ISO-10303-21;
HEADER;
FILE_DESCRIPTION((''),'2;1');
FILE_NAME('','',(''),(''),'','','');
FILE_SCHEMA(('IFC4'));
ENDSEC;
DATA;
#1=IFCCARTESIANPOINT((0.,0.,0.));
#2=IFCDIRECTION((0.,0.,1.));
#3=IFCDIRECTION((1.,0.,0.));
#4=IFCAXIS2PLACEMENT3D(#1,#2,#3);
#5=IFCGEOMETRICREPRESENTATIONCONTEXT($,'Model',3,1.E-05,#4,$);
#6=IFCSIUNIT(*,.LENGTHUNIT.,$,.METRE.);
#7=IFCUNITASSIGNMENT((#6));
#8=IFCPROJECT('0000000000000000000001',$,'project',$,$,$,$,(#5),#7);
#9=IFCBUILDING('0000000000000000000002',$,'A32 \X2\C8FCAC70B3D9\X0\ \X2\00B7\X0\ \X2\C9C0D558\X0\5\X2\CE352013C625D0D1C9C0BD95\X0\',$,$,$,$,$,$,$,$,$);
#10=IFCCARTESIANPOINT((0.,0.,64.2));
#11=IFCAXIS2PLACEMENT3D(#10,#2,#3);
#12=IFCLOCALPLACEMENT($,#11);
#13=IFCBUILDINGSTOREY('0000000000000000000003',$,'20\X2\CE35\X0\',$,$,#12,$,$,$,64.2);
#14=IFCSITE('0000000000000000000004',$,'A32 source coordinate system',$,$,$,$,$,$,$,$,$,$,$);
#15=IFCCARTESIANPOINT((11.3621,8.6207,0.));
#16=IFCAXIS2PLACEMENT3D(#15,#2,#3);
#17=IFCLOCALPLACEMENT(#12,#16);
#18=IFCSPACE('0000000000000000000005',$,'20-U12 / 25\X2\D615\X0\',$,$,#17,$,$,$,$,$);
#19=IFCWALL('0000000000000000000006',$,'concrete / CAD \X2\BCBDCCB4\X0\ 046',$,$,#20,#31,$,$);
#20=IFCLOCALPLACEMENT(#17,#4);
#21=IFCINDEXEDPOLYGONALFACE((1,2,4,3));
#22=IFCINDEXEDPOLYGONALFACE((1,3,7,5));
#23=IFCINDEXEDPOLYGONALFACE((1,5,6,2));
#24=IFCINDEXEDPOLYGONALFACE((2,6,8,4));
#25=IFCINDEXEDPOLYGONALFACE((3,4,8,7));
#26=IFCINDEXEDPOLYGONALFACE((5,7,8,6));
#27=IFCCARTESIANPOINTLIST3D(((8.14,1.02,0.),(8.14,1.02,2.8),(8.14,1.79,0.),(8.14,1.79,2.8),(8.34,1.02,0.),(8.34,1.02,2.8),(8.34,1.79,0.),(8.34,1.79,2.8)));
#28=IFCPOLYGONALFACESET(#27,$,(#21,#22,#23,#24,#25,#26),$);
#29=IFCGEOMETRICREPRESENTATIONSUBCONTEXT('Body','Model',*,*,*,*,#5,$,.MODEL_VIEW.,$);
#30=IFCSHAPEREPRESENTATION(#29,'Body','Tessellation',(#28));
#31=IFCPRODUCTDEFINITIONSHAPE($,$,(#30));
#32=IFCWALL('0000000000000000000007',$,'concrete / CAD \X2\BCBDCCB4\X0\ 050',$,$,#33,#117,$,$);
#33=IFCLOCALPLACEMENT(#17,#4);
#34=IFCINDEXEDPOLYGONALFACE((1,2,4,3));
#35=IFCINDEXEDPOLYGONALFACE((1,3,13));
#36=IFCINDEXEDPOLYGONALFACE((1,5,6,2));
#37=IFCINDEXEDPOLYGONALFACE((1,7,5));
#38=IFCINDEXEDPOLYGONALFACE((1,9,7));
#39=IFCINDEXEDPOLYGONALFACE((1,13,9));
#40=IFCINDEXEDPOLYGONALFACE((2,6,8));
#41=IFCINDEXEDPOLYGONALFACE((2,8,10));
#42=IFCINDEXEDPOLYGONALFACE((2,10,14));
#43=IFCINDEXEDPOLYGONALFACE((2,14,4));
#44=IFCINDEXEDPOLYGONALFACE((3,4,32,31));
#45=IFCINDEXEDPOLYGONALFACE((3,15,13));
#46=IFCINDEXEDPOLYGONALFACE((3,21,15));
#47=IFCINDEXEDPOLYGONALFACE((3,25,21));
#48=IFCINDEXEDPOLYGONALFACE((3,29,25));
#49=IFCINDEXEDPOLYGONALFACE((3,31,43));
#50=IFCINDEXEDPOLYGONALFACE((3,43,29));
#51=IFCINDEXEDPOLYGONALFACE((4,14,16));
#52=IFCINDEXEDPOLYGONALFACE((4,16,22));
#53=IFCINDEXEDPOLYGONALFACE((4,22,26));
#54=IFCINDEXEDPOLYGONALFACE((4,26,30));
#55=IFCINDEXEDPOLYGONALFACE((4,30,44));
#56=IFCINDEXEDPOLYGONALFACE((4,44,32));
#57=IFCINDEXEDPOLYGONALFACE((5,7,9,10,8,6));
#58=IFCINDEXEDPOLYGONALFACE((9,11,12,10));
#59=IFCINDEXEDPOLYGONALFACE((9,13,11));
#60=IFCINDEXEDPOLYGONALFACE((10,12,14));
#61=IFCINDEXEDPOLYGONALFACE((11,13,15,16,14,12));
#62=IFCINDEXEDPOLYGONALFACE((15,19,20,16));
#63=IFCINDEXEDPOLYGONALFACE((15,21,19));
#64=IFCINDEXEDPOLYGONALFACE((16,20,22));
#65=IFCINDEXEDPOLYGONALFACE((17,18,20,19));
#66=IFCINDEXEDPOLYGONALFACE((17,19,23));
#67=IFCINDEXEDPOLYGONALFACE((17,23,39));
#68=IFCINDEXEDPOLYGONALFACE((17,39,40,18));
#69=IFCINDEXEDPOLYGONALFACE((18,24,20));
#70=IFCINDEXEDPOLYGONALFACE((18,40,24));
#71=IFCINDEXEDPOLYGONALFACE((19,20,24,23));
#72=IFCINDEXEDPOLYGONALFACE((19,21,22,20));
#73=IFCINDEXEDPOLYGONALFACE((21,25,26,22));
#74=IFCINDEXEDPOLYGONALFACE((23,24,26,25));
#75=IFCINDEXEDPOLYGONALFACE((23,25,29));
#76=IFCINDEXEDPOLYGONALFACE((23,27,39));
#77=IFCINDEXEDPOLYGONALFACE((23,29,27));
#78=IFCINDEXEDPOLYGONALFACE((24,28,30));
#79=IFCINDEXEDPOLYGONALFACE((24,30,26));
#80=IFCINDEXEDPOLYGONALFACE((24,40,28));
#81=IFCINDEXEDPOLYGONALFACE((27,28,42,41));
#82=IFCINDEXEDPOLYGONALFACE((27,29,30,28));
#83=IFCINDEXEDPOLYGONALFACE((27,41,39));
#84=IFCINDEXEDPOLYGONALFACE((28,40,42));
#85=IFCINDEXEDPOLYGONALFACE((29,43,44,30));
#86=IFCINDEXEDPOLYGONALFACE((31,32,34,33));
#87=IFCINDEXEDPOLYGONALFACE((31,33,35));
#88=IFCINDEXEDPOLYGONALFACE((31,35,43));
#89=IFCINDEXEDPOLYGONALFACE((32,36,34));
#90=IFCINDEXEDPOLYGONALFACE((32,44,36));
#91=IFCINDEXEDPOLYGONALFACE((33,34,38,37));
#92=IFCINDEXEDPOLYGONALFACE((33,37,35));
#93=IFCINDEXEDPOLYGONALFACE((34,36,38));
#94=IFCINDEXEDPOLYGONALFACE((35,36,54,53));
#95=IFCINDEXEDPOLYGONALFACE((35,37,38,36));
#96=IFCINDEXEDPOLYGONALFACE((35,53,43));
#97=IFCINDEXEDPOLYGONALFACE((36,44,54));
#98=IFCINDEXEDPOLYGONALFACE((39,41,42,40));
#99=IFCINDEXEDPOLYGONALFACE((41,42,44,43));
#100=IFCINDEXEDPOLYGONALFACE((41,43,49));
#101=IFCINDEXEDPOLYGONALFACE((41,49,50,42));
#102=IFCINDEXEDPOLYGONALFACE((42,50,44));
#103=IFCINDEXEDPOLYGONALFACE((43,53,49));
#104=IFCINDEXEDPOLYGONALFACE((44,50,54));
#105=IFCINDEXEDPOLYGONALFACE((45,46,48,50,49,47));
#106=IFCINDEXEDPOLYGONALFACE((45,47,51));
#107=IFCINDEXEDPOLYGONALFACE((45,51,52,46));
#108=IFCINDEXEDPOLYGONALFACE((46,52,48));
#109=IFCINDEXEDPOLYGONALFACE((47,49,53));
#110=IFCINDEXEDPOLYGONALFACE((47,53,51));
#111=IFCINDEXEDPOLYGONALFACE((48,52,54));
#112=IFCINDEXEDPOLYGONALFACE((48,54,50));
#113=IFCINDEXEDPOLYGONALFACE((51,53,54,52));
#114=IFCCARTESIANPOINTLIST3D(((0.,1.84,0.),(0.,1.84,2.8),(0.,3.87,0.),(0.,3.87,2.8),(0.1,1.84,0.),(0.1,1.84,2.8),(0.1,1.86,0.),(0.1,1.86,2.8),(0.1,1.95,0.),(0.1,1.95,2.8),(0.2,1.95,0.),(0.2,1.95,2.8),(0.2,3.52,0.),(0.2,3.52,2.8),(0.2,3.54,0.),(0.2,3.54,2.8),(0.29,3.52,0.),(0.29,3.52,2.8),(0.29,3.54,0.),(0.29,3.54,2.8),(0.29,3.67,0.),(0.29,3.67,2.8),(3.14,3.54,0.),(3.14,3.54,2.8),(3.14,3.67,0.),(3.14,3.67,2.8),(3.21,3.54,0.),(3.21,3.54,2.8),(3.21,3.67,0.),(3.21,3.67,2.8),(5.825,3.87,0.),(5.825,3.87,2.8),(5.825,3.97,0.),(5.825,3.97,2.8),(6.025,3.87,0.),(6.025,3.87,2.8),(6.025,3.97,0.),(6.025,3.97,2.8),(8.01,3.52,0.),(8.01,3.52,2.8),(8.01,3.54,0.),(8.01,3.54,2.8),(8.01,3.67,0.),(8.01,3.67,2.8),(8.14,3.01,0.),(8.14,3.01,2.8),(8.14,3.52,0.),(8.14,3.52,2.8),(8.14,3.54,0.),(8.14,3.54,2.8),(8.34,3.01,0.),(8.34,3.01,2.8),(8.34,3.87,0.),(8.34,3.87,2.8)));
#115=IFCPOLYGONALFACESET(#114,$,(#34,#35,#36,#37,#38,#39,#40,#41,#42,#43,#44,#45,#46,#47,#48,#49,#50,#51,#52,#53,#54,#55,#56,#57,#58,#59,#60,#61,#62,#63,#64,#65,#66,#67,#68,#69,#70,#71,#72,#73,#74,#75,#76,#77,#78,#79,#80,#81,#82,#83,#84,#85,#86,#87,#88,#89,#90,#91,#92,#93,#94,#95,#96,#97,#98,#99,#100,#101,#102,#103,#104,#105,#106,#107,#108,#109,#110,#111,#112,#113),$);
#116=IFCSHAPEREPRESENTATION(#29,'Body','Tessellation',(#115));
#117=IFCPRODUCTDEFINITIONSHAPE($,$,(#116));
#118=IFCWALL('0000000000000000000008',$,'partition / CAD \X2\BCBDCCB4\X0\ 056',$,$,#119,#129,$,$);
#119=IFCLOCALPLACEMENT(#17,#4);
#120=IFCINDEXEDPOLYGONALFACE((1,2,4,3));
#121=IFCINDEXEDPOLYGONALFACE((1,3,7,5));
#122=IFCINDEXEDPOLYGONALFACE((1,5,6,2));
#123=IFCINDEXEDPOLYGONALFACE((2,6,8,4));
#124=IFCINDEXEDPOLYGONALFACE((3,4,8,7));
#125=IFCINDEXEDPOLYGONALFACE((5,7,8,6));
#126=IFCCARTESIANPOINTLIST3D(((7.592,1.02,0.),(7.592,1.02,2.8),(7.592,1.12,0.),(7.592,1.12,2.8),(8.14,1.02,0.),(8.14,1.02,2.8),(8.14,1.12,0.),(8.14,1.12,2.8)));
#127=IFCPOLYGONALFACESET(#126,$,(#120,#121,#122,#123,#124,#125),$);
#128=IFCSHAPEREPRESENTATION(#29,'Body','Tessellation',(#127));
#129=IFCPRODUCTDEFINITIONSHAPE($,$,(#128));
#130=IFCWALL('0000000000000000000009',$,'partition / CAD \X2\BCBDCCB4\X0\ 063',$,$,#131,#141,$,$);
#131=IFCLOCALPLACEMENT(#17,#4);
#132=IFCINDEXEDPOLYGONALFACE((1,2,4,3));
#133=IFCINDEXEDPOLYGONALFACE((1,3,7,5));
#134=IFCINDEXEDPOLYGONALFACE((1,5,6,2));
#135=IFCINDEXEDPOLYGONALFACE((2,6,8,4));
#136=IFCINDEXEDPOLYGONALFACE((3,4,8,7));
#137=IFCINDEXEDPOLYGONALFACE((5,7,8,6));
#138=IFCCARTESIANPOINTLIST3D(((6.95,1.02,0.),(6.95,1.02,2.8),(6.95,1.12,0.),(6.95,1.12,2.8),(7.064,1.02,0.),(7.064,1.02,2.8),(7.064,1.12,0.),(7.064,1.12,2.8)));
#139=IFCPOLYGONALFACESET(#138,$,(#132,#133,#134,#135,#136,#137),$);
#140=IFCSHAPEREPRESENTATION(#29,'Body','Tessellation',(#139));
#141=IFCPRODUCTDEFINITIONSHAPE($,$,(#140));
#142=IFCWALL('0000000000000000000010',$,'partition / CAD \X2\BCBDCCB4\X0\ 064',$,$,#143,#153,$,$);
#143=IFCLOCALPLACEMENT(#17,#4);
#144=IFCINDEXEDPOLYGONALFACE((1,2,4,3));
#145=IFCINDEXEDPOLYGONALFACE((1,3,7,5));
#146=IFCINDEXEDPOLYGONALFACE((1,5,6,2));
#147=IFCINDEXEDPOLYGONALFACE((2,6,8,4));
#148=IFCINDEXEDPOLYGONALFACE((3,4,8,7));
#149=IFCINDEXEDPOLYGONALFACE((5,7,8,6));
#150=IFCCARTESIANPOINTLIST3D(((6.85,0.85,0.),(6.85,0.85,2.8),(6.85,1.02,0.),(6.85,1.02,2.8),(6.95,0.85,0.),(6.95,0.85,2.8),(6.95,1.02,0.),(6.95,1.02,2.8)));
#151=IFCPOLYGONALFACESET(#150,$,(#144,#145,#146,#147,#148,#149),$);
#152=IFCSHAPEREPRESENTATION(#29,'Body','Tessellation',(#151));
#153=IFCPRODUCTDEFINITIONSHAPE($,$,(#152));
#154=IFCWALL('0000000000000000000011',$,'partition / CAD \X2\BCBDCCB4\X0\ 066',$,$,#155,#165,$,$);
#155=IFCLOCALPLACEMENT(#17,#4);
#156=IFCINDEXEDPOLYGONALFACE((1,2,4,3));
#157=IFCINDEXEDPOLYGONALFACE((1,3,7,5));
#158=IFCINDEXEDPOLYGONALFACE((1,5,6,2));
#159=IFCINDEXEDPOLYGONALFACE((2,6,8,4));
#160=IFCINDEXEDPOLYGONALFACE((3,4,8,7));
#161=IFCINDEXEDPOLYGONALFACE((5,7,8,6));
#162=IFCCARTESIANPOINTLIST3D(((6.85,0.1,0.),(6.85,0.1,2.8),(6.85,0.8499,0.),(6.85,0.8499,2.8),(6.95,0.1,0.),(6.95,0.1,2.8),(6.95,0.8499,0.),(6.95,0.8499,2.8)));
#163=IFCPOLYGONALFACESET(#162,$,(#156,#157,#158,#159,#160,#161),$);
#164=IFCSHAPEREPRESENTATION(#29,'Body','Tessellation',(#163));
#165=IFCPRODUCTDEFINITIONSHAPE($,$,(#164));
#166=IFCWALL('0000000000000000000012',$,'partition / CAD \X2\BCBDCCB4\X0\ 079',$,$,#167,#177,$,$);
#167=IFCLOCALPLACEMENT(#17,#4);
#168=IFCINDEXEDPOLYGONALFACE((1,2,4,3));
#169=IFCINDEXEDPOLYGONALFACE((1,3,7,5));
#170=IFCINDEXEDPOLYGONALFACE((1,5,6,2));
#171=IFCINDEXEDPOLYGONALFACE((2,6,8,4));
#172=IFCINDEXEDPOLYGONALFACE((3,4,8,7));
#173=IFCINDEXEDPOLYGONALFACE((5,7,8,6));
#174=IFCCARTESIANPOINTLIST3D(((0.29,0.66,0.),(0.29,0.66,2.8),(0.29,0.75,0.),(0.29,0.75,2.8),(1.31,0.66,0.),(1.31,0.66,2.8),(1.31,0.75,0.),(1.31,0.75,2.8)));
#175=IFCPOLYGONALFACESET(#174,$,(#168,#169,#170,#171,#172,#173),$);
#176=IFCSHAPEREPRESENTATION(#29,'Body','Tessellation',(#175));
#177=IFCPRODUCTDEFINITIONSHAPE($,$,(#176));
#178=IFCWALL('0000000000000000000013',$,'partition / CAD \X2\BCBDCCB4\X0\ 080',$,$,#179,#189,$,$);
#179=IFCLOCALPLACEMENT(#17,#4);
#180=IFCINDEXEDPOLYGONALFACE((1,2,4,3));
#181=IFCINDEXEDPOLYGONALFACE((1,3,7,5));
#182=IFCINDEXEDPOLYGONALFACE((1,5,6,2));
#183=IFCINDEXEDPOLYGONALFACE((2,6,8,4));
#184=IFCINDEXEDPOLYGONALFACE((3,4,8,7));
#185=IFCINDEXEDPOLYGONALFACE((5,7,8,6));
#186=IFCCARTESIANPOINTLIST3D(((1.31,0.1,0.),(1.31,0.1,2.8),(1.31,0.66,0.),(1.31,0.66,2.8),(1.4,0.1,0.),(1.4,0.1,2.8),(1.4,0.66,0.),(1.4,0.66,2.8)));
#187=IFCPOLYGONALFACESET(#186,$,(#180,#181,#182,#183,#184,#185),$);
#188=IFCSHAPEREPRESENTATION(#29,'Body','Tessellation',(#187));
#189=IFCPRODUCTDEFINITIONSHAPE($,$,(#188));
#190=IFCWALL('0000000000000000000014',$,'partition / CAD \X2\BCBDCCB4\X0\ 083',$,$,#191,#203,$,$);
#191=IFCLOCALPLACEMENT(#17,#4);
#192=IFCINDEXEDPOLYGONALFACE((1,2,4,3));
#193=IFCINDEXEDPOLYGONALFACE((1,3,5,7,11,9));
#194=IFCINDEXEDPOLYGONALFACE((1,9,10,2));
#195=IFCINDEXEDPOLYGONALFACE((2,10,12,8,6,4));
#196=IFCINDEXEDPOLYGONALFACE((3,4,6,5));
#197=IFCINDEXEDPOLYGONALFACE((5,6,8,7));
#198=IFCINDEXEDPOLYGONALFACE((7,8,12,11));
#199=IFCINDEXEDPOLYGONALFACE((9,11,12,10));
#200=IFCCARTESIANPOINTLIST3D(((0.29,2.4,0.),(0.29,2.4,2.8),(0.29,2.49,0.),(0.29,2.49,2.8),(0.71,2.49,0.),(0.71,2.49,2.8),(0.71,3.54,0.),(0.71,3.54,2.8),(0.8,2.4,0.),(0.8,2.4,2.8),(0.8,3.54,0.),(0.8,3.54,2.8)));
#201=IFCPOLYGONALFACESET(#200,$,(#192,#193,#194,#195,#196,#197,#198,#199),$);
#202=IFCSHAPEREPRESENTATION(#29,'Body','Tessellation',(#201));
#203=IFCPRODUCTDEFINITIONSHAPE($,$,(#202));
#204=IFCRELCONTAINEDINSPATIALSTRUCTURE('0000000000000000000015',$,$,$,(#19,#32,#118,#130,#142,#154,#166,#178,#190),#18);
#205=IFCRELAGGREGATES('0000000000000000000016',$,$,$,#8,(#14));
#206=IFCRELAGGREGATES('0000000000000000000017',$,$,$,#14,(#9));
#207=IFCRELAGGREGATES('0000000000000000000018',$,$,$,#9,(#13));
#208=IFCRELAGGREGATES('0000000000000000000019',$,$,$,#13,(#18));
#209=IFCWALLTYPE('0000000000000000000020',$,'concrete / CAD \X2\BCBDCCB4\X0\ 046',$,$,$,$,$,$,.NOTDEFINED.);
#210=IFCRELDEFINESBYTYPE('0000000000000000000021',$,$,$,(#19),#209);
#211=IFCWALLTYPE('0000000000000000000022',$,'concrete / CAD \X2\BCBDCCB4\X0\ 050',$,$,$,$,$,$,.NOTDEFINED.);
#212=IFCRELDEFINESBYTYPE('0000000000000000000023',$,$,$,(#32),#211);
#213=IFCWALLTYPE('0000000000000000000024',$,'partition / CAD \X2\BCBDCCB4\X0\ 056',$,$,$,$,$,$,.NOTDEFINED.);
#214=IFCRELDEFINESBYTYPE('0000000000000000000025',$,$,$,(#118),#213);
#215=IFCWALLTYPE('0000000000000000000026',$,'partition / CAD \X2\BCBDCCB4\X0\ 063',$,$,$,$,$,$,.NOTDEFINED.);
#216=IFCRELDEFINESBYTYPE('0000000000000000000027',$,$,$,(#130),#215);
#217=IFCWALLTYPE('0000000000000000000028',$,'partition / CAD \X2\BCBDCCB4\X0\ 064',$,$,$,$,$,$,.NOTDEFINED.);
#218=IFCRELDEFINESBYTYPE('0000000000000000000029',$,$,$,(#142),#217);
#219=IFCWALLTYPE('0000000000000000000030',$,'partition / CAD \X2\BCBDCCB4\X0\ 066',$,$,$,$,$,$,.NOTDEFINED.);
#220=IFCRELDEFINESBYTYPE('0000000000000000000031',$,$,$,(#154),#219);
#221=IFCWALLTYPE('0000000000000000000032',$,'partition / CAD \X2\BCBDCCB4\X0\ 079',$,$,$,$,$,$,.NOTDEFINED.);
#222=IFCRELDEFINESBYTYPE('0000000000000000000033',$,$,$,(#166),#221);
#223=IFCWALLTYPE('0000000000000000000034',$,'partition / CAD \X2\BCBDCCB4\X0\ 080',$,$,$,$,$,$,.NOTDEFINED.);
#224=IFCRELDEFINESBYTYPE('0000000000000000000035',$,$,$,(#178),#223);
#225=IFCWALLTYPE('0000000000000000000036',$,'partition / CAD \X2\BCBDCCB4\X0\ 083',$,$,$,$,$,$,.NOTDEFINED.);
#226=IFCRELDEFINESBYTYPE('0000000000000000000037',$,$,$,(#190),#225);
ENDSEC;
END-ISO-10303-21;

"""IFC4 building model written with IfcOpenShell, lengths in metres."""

from ifc_helpers import new_model, si_unit, frame, origin, origin_with_axes, place, context, subcontext, project, spatial, polyline, outline, extrude, source, transform, mapped, type_object, type_shapes, element, save


model = new_model("IFC4")

# Units and contexts
model_context = context("Model", 3, precision=1e-05, world=origin_with_axes())
body_context = subcontext(model_context, "Body", "Model", "MODEL_VIEW")
ifc_project = project(units=[si_unit("LENGTHUNIT", "METRE")], contexts=[model_context])

# Site, building, storey, space
site = spatial("IfcSite", under=ifc_project, Name="A32 source coordinate system")
building = spatial("IfcBuilding", under=site, Name="A32 주거동 · 지하5층–옥탑지붕")
storey_placement = place(None, frame((0.0, 0.0, 64.2), z_axis=(0.0, 0.0, 1.0), x_axis=(1.0, 0.0, 0.0)))
storey = spatial("IfcBuildingStorey", under=building, at=storey_placement, Name="20층", Elevation=64.2)
space_1_placement = place(storey_placement, frame((11.3621, 8.6207, 0.0), z_axis=(0.0, 0.0, 1.0), x_axis=(1.0, 0.0, 0.0)))
space_1 = spatial("IfcSpace", under=storey, at=space_1_placement, Name="20-U12 / 25형")

# Walls
wall_type_1 = type_object("IfcWallType", Name="concrete / CAD 벽체 046", PredefinedType="NOTDEFINED")
shared_shape_1 = source(origin(), body_context, "Body", "SweptSolid", [
    extrude(outline(polyline([(8.14, 1.02), (8.14, 1.79), (8.34, 1.79), (8.34, 1.02), (8.14, 1.02)])), origin(), (0.0, 0.0, 1.0), 2.8),
])
type_shapes(wall_type_1, [shared_shape_1])
wall_1_placement = place(space_1_placement, origin_with_axes())
element("IfcWall", 1, at=wall_1_placement, inside=space_1, type_object=wall_type_1, Name="concrete / CAD 벽체 046", context=body_context, shape_type="MappedRepresentation", body=[
    mapped(shared_shape_1, transform((0.0, 0.0, 0.0), scale=1.0)),
])
wall_type_2 = type_object("IfcWallType", Name="concrete / CAD 벽체 050", PredefinedType="NOTDEFINED")
shared_shape_2 = source(origin(), body_context, "Body", "SweptSolid", [
    extrude(outline(polyline([(8.01, 3.52), (0.29, 3.52), (0.29, 3.54), (0.2, 3.54), (0.2, 3.52), (0.2, 1.95), (0.1, 1.95), (0.1, 1.86), (0.1, 1.84), (0.0, 1.84), (0.0, 3.87), (5.825, 3.87), (5.825, 3.97), (6.025, 3.97), (6.025, 3.87), (8.34, 3.87), (8.34, 3.01), (8.14, 3.01), (8.14, 3.52), (8.14, 3.54), (8.01, 3.54), (8.01, 3.52)]), holes=[polyline([(3.14, 3.54), (3.14, 3.67), (0.29, 3.67), (0.29, 3.54), (3.14, 3.54)]), polyline([(8.01, 3.67), (3.21, 3.67), (3.21, 3.54), (8.01, 3.54), (8.01, 3.67)])]), origin(), (0.0, 0.0, 1.0), 2.8),
])
type_shapes(wall_type_2, [shared_shape_2])
wall_2_placement = place(space_1_placement, origin_with_axes())
element("IfcWall", 2, at=wall_2_placement, inside=space_1, type_object=wall_type_2, Name="concrete / CAD 벽체 050", context=body_context, shape_type="MappedRepresentation", body=[
    mapped(shared_shape_2, transform((0.0, 0.0, 0.0), scale=1.0)),
])
wall_type_3 = type_object("IfcWallType", Name="partition / CAD 벽체 056", PredefinedType="NOTDEFINED")
shared_shape_3 = source(origin(), body_context, "Body", "SweptSolid", [
    extrude(outline(polyline([(7.592, 1.12), (8.14, 1.12), (8.14, 1.02), (7.592, 1.02), (7.592, 1.12)])), origin(), (0.0, 0.0, 1.0), 2.8),
])
type_shapes(wall_type_3, [shared_shape_3])
wall_3_placement = place(space_1_placement, origin_with_axes())
element("IfcWall", 3, at=wall_3_placement, inside=space_1, type_object=wall_type_3, Name="partition / CAD 벽체 056", context=body_context, shape_type="MappedRepresentation", body=[
    mapped(shared_shape_3, transform((0.0, 0.0, 0.0), scale=1.0)),
])
wall_type_4 = type_object("IfcWallType", Name="partition / CAD 벽체 063", PredefinedType="NOTDEFINED")
shared_shape_4 = source(origin(), body_context, "Body", "SweptSolid", [
    extrude(outline(polyline([(6.95, 1.12), (7.064, 1.12), (7.064, 1.02), (6.95, 1.02), (6.95, 1.12)])), origin(), (0.0, 0.0, 1.0), 2.8),
])
type_shapes(wall_type_4, [shared_shape_4])
wall_4_placement = place(space_1_placement, origin_with_axes())
element("IfcWall", 4, at=wall_4_placement, inside=space_1, type_object=wall_type_4, Name="partition / CAD 벽체 063", context=body_context, shape_type="MappedRepresentation", body=[
    mapped(shared_shape_4, transform((0.0, 0.0, 0.0), scale=1.0)),
])
wall_type_5 = type_object("IfcWallType", Name="partition / CAD 벽체 064", PredefinedType="NOTDEFINED")
shared_shape_5 = source(origin(), body_context, "Body", "SweptSolid", [
    extrude(outline(polyline([(6.95, 0.85), (6.85, 0.85), (6.85, 1.02), (6.95, 1.02), (6.95, 0.85)])), origin(), (0.0, 0.0, 1.0), 2.8),
])
type_shapes(wall_type_5, [shared_shape_5])
wall_5_placement = place(space_1_placement, origin_with_axes())
element("IfcWall", 5, at=wall_5_placement, inside=space_1, type_object=wall_type_5, Name="partition / CAD 벽체 064", context=body_context, shape_type="MappedRepresentation", body=[
    mapped(shared_shape_5, transform((0.0, 0.0, 0.0), scale=1.0)),
])
wall_type_6 = type_object("IfcWallType", Name="partition / CAD 벽체 066", PredefinedType="NOTDEFINED")
shared_shape_6 = source(origin(), body_context, "Body", "SweptSolid", [
    extrude(outline(polyline([(6.85, 0.8499), (6.95, 0.8499), (6.95, 0.1), (6.85, 0.1), (6.85, 0.8499)])), origin(), (0.0, 0.0, 1.0), 2.8),
])
type_shapes(wall_type_6, [shared_shape_6])
wall_6_placement = place(space_1_placement, origin_with_axes())
element("IfcWall", 6, at=wall_6_placement, inside=space_1, type_object=wall_type_6, Name="partition / CAD 벽체 066", context=body_context, shape_type="MappedRepresentation", body=[
    mapped(shared_shape_6, transform((0.0, 0.0, 0.0), scale=1.0)),
])
wall_type_7 = type_object("IfcWallType", Name="partition / CAD 벽체 079", PredefinedType="NOTDEFINED")
shared_shape_7 = source(origin(), body_context, "Body", "SweptSolid", [
    extrude(outline(polyline([(0.29, 0.75), (1.31, 0.75), (1.31, 0.66), (0.29, 0.66), (0.29, 0.75)])), origin(), (0.0, 0.0, 1.0), 2.8),
])
type_shapes(wall_type_7, [shared_shape_7])
wall_7_placement = place(space_1_placement, origin_with_axes())
element("IfcWall", 7, at=wall_7_placement, inside=space_1, type_object=wall_type_7, Name="partition / CAD 벽체 079", context=body_context, shape_type="MappedRepresentation", body=[
    mapped(shared_shape_7, transform((0.0, 0.0, 0.0), scale=1.0)),
])
wall_type_8 = type_object("IfcWallType", Name="partition / CAD 벽체 080", PredefinedType="NOTDEFINED")
shared_shape_8 = source(origin(), body_context, "Body", "SweptSolid", [
    extrude(outline(polyline([(1.4, 0.66), (1.4, 0.1), (1.31, 0.1), (1.31, 0.66), (1.4, 0.66)])), origin(), (0.0, 0.0, 1.0), 2.8),
])
type_shapes(wall_type_8, [shared_shape_8])
wall_8_placement = place(space_1_placement, origin_with_axes())
element("IfcWall", 8, at=wall_8_placement, inside=space_1, type_object=wall_type_8, Name="partition / CAD 벽체 080", context=body_context, shape_type="MappedRepresentation", body=[
    mapped(shared_shape_8, transform((0.0, 0.0, 0.0), scale=1.0)),
])
wall_type_9 = type_object("IfcWallType", Name="partition / CAD 벽체 083", PredefinedType="NOTDEFINED")
shared_shape_9 = source(origin(), body_context, "Body", "SweptSolid", [
    extrude(outline(polyline([(0.71, 2.49), (0.71, 3.54), (0.8, 3.54), (0.8, 2.4), (0.29, 2.4), (0.29, 2.49), (0.71, 2.49)])), origin(), (0.0, 0.0, 1.0), 2.8),
])
type_shapes(wall_type_9, [shared_shape_9])
wall_9_placement = place(space_1_placement, origin_with_axes())
element("IfcWall", 9, at=wall_9_placement, inside=space_1, type_object=wall_type_9, Name="partition / CAD 벽체 083", context=body_context, shape_type="MappedRepresentation", body=[
    mapped(shared_shape_9, transform((0.0, 0.0, 0.0), scale=1.0)),
])

save(model, "model.ifc")
